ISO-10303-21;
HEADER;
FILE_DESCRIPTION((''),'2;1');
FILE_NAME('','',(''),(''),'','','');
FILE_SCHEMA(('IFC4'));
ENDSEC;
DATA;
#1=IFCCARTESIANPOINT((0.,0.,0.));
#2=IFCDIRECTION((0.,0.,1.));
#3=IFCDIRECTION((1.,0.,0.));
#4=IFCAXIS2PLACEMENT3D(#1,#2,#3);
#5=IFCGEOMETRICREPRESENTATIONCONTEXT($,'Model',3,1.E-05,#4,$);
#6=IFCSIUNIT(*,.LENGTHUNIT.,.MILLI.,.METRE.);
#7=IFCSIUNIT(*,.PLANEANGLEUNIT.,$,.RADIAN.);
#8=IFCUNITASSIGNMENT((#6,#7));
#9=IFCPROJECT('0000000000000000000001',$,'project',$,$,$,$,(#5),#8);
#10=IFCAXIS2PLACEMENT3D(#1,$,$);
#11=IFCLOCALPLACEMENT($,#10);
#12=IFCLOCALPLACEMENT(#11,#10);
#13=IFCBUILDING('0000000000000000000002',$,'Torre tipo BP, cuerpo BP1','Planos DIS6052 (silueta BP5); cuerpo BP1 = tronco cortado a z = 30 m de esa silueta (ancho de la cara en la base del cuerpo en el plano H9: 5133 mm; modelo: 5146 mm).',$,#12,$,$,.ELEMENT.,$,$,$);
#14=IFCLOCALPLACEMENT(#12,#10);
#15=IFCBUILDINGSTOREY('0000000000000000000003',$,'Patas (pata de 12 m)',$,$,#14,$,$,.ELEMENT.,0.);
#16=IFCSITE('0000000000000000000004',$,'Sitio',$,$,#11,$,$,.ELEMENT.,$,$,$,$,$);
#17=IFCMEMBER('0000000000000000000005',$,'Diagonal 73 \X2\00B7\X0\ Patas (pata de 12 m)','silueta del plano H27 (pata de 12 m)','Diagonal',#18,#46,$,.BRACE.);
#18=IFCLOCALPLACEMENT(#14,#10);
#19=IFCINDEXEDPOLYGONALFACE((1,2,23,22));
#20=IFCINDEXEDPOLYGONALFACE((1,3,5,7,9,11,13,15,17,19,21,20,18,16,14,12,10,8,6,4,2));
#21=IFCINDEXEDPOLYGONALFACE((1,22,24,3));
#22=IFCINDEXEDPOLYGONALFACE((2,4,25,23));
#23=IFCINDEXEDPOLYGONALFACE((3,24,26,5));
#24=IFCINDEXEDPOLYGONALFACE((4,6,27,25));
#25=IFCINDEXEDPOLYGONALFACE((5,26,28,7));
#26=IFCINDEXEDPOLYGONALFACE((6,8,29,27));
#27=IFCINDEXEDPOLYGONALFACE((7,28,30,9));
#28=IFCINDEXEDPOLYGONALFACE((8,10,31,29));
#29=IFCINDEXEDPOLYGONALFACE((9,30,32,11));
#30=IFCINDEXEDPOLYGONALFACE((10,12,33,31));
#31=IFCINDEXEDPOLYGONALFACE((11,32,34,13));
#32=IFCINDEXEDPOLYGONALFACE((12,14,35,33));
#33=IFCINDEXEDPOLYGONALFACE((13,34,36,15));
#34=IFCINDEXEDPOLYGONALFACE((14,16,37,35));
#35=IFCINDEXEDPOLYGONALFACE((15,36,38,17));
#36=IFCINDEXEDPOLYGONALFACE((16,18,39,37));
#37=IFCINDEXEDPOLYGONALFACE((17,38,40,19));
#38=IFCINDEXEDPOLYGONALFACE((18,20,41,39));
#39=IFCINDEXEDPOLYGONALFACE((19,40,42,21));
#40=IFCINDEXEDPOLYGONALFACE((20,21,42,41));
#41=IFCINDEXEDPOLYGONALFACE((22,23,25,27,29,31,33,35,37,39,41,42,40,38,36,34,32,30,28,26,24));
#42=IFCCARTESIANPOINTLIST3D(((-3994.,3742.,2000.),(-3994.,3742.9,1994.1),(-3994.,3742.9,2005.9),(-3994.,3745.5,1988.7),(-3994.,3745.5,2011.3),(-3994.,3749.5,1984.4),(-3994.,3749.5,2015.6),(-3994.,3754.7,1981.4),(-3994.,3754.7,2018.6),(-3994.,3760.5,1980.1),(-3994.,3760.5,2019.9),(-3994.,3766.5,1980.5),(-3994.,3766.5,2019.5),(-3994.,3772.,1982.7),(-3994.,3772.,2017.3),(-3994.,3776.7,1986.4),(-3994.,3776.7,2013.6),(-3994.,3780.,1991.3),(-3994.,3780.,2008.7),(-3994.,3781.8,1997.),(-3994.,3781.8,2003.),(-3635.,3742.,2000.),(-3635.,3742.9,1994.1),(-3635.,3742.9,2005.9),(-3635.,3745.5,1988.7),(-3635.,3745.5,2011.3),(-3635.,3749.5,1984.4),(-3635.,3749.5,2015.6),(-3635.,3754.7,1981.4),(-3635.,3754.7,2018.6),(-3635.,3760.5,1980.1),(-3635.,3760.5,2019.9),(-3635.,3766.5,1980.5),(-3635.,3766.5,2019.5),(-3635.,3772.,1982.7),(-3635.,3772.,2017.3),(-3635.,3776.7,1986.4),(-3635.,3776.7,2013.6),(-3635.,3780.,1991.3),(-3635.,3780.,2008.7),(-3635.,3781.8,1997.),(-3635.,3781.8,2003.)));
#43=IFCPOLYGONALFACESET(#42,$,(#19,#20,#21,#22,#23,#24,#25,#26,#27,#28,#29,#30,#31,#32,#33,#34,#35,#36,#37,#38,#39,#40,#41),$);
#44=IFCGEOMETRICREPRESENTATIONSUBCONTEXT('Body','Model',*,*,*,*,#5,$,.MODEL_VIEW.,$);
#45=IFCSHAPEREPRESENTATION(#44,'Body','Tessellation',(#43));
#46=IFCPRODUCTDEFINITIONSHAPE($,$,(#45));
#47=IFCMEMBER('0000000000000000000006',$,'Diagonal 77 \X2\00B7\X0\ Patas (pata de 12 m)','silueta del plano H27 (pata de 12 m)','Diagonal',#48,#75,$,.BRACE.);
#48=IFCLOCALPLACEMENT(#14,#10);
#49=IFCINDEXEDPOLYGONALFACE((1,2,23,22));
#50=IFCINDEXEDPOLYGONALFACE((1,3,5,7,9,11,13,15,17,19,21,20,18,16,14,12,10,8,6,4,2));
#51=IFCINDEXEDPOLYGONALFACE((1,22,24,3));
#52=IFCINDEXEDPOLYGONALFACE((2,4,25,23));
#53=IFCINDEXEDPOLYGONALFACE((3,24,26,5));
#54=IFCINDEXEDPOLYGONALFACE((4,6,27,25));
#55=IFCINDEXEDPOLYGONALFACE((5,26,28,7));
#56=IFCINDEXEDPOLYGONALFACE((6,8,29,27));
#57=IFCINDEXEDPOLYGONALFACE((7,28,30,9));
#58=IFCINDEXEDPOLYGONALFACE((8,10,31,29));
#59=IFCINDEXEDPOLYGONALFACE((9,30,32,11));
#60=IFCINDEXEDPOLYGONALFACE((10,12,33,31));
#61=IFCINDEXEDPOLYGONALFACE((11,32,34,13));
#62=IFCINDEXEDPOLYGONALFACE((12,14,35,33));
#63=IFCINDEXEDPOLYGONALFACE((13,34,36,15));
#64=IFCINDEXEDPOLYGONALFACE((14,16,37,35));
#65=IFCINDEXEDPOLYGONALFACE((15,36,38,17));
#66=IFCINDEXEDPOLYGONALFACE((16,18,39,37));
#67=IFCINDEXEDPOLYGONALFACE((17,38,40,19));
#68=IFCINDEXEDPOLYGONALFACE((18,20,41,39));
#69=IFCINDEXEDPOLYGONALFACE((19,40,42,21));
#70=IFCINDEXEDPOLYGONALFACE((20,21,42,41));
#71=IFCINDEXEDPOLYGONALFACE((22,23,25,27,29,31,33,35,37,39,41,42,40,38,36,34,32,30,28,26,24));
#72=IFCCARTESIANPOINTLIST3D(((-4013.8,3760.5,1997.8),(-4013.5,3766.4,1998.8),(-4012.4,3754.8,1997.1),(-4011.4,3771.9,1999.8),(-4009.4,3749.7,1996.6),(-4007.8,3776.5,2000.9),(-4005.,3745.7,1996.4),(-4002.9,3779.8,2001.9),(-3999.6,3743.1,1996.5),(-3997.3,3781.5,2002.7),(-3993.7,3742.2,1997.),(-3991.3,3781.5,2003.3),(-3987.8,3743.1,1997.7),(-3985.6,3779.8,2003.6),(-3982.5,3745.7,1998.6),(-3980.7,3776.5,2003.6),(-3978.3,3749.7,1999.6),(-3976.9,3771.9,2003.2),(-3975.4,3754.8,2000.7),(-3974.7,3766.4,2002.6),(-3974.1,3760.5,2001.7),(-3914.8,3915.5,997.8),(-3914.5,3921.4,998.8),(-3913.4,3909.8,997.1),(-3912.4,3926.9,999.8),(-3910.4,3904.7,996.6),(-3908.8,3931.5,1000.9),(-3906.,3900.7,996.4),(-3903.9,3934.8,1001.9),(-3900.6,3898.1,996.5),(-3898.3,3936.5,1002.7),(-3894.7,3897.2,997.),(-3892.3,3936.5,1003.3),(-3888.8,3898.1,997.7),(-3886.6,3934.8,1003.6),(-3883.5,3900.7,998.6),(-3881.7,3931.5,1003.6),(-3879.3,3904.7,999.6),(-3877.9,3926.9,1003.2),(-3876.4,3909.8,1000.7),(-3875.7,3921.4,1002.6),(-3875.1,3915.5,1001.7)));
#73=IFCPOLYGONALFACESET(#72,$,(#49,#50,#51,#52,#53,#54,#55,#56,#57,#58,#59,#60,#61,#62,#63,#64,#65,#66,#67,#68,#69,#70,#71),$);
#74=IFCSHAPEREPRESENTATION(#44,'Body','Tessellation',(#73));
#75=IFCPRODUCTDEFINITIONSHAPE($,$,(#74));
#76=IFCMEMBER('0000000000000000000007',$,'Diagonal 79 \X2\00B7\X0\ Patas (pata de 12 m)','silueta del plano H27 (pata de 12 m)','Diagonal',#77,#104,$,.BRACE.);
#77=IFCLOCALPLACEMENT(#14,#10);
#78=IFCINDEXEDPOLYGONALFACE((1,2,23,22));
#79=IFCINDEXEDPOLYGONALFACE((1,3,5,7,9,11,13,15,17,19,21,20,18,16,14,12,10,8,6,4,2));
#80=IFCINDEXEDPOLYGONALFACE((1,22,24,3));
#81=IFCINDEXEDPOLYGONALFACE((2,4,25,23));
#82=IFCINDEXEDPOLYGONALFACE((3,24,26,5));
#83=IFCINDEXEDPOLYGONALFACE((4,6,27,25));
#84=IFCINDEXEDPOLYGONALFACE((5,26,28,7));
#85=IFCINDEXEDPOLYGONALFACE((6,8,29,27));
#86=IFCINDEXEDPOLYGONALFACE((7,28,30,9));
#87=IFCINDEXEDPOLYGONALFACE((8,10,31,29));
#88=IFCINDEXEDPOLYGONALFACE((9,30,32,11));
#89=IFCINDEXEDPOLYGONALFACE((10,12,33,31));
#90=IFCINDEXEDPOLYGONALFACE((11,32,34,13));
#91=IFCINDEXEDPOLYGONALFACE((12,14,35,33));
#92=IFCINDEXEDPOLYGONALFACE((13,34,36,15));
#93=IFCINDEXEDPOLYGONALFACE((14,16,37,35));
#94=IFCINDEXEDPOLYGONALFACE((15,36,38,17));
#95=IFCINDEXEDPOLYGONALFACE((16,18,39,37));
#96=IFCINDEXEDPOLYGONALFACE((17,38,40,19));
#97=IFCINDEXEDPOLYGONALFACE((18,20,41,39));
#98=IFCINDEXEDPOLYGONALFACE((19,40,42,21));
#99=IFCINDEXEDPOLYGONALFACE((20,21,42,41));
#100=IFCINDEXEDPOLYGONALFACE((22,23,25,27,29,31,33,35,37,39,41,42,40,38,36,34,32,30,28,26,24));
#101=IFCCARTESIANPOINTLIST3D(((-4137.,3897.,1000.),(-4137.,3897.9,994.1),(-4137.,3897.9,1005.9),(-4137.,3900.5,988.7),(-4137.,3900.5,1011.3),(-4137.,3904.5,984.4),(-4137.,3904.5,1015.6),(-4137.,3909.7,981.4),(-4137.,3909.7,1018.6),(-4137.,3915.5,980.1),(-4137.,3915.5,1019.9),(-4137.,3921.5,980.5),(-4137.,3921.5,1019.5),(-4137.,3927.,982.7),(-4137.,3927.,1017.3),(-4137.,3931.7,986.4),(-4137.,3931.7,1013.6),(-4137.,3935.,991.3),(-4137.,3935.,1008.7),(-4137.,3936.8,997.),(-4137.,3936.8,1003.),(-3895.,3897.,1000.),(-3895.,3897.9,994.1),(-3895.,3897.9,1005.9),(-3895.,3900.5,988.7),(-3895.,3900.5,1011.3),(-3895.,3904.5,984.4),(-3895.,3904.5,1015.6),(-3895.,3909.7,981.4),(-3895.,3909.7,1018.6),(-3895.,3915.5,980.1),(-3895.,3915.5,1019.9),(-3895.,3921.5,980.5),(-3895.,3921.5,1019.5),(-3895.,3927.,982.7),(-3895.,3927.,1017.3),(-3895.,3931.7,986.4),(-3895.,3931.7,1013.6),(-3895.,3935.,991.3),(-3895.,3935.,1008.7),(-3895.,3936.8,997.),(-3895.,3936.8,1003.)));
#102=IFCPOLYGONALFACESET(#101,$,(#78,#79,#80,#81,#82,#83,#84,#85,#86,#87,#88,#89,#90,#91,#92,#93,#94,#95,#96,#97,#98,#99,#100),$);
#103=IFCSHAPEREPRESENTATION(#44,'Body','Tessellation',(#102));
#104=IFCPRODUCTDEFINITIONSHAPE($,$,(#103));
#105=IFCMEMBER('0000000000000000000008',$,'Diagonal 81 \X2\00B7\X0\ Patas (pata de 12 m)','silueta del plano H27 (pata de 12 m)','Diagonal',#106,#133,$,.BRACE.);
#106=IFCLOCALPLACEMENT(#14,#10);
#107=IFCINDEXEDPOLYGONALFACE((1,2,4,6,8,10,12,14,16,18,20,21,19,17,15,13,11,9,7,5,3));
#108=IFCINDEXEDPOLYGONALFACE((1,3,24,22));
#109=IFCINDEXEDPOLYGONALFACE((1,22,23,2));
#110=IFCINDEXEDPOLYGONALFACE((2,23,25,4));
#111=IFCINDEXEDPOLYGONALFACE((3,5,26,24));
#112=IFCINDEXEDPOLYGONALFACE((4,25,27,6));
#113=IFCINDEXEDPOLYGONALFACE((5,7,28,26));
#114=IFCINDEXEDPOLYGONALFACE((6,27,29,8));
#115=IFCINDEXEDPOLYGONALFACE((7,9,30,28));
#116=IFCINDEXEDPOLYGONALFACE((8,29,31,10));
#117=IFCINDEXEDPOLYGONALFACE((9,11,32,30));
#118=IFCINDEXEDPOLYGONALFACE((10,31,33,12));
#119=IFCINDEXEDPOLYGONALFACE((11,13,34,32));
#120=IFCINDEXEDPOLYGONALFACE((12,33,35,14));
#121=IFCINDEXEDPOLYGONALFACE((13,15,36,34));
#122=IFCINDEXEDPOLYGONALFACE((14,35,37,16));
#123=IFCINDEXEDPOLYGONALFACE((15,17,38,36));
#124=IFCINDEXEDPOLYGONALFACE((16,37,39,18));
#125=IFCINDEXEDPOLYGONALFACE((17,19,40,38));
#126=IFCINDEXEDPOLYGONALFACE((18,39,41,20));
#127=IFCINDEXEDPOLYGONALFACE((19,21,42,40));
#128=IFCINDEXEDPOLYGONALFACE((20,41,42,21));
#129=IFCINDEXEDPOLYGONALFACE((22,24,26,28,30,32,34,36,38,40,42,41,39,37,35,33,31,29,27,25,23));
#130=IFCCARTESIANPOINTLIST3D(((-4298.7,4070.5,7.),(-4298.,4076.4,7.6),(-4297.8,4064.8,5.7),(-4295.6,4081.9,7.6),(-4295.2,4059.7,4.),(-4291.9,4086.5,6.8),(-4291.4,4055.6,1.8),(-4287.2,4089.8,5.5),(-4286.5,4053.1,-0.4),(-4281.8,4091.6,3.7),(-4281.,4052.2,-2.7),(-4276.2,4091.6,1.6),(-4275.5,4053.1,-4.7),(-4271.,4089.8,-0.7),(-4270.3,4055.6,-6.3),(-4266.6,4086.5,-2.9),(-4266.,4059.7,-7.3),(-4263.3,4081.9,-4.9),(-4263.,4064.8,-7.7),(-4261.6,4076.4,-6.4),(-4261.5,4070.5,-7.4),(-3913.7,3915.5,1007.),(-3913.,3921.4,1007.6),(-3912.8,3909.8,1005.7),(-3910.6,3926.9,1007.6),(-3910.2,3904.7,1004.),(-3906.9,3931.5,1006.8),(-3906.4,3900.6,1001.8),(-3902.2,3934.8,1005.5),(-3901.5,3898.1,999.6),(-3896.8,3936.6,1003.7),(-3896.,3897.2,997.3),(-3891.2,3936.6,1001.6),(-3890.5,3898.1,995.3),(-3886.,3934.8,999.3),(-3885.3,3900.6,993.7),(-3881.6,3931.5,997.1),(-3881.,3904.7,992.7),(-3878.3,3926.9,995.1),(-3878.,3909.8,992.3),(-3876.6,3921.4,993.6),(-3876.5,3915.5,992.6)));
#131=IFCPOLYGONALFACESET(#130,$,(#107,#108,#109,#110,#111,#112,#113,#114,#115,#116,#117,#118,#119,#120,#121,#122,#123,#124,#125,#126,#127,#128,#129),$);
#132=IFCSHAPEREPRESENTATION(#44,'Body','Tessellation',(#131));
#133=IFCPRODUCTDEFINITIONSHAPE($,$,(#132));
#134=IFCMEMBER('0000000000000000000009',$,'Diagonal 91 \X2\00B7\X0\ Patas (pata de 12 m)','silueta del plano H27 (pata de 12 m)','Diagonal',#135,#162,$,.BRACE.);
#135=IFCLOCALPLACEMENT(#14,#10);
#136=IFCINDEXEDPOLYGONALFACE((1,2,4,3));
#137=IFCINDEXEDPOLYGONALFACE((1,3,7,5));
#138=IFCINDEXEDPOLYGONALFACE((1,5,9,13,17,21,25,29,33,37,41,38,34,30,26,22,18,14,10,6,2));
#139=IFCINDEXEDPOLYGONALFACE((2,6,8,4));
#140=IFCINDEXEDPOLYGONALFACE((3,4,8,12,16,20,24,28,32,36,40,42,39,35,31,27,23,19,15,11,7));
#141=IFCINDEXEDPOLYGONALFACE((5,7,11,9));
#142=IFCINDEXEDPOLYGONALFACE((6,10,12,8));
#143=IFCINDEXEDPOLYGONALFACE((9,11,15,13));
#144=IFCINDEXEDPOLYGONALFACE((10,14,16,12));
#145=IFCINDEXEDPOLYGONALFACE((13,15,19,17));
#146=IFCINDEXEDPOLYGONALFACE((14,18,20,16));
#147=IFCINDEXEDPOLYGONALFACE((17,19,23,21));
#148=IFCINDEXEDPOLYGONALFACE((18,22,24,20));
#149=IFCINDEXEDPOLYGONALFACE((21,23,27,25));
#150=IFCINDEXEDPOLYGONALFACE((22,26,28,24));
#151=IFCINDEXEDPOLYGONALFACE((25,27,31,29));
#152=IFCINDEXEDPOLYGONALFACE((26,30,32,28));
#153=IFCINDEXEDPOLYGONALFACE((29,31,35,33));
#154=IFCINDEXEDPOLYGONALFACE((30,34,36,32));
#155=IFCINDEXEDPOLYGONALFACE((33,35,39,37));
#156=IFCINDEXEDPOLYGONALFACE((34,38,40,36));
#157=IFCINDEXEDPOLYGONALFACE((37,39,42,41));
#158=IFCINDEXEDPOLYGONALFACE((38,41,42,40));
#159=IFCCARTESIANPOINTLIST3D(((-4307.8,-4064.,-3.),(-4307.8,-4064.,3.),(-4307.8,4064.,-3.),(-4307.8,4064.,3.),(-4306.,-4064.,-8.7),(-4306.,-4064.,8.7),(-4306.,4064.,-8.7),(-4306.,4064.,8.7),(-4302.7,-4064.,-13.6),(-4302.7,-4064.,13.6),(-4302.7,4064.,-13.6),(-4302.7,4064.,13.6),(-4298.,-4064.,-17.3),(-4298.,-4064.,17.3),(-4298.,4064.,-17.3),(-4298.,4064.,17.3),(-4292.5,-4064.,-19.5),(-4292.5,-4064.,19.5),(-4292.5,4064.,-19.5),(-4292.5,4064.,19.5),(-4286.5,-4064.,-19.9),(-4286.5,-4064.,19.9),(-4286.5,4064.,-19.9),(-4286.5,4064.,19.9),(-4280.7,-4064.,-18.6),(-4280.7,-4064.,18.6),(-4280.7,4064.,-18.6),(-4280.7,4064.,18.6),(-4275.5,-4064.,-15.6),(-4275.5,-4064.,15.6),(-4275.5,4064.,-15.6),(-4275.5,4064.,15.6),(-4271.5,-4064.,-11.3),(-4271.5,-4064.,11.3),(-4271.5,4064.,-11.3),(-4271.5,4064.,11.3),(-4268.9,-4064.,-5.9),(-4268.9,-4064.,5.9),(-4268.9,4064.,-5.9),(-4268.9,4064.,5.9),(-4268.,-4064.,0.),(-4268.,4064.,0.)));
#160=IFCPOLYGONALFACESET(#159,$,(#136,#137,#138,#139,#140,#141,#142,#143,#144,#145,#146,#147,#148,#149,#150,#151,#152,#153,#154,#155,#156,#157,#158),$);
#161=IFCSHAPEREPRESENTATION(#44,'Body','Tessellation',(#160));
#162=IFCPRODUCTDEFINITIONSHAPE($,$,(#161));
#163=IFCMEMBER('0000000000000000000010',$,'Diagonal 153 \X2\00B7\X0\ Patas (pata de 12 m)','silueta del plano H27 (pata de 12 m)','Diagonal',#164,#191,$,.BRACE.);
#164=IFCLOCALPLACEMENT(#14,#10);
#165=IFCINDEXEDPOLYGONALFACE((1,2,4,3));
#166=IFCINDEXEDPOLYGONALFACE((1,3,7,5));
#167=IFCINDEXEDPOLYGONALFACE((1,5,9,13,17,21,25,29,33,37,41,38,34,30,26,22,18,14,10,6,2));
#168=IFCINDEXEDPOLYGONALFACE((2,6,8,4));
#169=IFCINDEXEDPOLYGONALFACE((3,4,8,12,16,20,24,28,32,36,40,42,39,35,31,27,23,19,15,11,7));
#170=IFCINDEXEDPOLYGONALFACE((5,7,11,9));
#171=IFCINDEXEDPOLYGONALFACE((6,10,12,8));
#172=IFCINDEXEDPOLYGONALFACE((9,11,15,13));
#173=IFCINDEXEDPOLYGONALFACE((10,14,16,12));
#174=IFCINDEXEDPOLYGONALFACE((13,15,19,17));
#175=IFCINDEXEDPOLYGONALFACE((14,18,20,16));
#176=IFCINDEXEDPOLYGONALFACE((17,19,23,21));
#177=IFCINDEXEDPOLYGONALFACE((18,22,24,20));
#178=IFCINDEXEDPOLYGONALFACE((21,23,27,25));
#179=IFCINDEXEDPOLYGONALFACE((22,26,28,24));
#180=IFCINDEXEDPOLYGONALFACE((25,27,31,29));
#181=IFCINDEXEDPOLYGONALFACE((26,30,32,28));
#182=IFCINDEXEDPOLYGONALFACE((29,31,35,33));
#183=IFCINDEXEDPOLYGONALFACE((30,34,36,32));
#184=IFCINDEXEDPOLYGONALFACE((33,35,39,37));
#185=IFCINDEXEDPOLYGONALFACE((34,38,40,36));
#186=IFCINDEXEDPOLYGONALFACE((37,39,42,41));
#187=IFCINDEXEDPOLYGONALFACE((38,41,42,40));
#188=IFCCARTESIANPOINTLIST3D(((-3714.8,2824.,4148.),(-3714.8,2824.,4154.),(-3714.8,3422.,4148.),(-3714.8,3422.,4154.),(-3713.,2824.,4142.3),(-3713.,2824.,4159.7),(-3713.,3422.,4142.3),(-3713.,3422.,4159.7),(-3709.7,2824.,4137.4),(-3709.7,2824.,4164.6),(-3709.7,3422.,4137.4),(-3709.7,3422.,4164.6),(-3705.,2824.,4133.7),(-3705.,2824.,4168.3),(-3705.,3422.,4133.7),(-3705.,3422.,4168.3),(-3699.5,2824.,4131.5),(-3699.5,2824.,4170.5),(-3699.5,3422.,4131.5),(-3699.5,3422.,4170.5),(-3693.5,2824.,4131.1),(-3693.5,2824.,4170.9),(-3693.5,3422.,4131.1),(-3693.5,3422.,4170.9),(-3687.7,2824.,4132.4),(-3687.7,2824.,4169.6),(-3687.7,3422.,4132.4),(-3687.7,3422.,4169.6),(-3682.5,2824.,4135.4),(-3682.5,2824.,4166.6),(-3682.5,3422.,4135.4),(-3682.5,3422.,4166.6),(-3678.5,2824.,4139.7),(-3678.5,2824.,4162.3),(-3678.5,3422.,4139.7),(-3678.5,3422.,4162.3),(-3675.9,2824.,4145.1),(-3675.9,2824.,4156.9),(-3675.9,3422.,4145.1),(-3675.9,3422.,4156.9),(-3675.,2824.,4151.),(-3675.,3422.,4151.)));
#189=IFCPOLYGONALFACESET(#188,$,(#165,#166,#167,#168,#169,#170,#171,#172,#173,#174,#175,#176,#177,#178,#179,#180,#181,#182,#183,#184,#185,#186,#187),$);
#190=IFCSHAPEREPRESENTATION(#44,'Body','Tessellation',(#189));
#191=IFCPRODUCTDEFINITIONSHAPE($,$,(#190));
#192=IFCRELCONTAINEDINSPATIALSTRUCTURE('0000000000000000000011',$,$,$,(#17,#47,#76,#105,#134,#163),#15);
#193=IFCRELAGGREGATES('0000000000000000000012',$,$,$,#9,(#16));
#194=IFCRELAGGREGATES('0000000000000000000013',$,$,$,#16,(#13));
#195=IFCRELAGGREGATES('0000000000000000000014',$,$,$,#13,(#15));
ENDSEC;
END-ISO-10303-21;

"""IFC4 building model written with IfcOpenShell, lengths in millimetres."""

from ifc_helpers import new_model, si_unit, frame, origin, origin_with_axes, place, context, subcontext, project, spatial, circle, extrude, element, save


model = new_model("IFC4")

# Units and contexts
model_context = context("Model", 3, precision=1e-05, world=origin_with_axes())
body_context = subcontext(model_context, "Body", "Model", "MODEL_VIEW")
ifc_project = project(units=[si_unit("LENGTHUNIT", "METRE", prefix="MILLI"), si_unit("PLANEANGLEUNIT", "RADIAN")], contexts=[model_context])

# Site, building, storey
site_placement = place(None, origin())
site = spatial("IfcSite", under=ifc_project, at=site_placement, Name="Sitio", CompositionType="ELEMENT")
building_placement = place(site_placement, origin())
building = spatial("IfcBuilding", under=site, at=building_placement, Name="Torre tipo BP, cuerpo BP1", Description="Planos DIS6052 (silueta BP5); cuerpo BP1 = tronco cortado a z = 30 m de esa silueta (ancho de la cara en la base del cuerpo en el plano H9: 5133 mm; modelo: 5146 mm).", CompositionType="ELEMENT")
storey_placement = place(building_placement, origin())
storey = spatial("IfcBuildingStorey", under=building, at=storey_placement, Name="Patas (pata de 12 m)", CompositionType="ELEMENT", Elevation=0.0)

# Members
member_1_placement = place(storey_placement, frame((-3994.0, 3762.0, 2000.0), z_axis=(1.0, 0.0, 0.0), x_axis=(0.0, -1.0, 0.0)))
element("IfcMember", 1, at=member_1_placement, inside=storey, Name="Diagonal 73 · Patas (pata de 12 m)", Description="silueta del plano H27 (pata de 12 m)", ObjectType="Diagonal", PredefinedType="BRACE", context=body_context, shape_type="SweptSolid", body=[
    extrude(circle(Radius=20.0), None, (0.0, 0.0, 1.0), 359.0),
])
member_2_placement = place(storey_placement, frame((-3895.0, 3917.0, 1000.0), z_axis=(-0.097367, -0.152443, 0.983504), x_axis=(0.015018, -0.988312, -0.151702)))
element("IfcMember", 2, at=member_2_placement, inside=storey, Name="Diagonal 77 · Patas (pata de 12 m)", Description="silueta del plano H27 (pata de 12 m)", ObjectType="Diagonal", PredefinedType="BRACE", context=body_context, shape_type="SweptSolid", body=[
    extrude(circle(Radius=20.0), None, (0.0, 0.0, 1.0), 1016.8),
])
member_3_placement = place(storey_placement, frame((-4137.0, 3917.0, 1000.0), z_axis=(1.0, 0.0, 0.0), x_axis=(0.0, -1.0, 0.0)))
element("IfcMember", 3, at=member_3_placement, inside=storey, Name="Diagonal 79 · Patas (pata de 12 m)", Description="silueta del plano H27 (pata de 12 m)", ObjectType="Diagonal", PredefinedType="BRACE", context=body_context, shape_type="SweptSolid", body=[
    extrude(circle(Radius=20.0), None, (0.0, 0.0, 1.0), 242.0),
])
member_4_placement = place(storey_placement, frame((-4280.0, 4072.0, 0.0), z_axis=(0.355591, -0.14316, 0.923613), x_axis=(-0.051436, -0.9897, -0.1336)))
element("IfcMember", 4, at=member_4_placement, inside=storey, Name="Diagonal 81 · Patas (pata de 12 m)", Description="silueta del plano H27 (pata de 12 m)", ObjectType="Diagonal", PredefinedType="BRACE", context=body_context, shape_type="SweptSolid", body=[
    extrude(circle(Radius=20.0), None, (0.0, 0.0, 1.0), 1082.7),
])
member_5_placement = place(storey_placement, frame((-4288.0, 4064.0, 0.0), z_axis=(0.0, -1.0, 0.0), x_axis=(1.0, 0.0, 0.0)))
element("IfcMember", 5, at=member_5_placement, inside=storey, Name="Diagonal 91 · Patas (pata de 12 m)", Description="silueta del plano H27 (pata de 12 m)", ObjectType="Diagonal", PredefinedType="BRACE", context=body_context, shape_type="SweptSolid", body=[
    extrude(circle(Radius=20.0), None, (0.0, 0.0, 1.0), 8128.0),
])
member_6_placement = place(storey_placement, frame((-3695.0, 3422.0, 4151.0), z_axis=(0.0, -1.0, 0.0), x_axis=(1.0, 0.0, 0.0)))
element("IfcMember", 6, at=member_6_placement, inside=storey, Name="Diagonal 153 · Patas (pata de 12 m)", Description="silueta del plano H27 (pata de 12 m)", ObjectType="Diagonal", PredefinedType="BRACE", context=body_context, shape_type="SweptSolid", body=[
    extrude(circle(Radius=20.0), None, (0.0, 0.0, 1.0), 598.0),
])

save(model, "model.ifc")
